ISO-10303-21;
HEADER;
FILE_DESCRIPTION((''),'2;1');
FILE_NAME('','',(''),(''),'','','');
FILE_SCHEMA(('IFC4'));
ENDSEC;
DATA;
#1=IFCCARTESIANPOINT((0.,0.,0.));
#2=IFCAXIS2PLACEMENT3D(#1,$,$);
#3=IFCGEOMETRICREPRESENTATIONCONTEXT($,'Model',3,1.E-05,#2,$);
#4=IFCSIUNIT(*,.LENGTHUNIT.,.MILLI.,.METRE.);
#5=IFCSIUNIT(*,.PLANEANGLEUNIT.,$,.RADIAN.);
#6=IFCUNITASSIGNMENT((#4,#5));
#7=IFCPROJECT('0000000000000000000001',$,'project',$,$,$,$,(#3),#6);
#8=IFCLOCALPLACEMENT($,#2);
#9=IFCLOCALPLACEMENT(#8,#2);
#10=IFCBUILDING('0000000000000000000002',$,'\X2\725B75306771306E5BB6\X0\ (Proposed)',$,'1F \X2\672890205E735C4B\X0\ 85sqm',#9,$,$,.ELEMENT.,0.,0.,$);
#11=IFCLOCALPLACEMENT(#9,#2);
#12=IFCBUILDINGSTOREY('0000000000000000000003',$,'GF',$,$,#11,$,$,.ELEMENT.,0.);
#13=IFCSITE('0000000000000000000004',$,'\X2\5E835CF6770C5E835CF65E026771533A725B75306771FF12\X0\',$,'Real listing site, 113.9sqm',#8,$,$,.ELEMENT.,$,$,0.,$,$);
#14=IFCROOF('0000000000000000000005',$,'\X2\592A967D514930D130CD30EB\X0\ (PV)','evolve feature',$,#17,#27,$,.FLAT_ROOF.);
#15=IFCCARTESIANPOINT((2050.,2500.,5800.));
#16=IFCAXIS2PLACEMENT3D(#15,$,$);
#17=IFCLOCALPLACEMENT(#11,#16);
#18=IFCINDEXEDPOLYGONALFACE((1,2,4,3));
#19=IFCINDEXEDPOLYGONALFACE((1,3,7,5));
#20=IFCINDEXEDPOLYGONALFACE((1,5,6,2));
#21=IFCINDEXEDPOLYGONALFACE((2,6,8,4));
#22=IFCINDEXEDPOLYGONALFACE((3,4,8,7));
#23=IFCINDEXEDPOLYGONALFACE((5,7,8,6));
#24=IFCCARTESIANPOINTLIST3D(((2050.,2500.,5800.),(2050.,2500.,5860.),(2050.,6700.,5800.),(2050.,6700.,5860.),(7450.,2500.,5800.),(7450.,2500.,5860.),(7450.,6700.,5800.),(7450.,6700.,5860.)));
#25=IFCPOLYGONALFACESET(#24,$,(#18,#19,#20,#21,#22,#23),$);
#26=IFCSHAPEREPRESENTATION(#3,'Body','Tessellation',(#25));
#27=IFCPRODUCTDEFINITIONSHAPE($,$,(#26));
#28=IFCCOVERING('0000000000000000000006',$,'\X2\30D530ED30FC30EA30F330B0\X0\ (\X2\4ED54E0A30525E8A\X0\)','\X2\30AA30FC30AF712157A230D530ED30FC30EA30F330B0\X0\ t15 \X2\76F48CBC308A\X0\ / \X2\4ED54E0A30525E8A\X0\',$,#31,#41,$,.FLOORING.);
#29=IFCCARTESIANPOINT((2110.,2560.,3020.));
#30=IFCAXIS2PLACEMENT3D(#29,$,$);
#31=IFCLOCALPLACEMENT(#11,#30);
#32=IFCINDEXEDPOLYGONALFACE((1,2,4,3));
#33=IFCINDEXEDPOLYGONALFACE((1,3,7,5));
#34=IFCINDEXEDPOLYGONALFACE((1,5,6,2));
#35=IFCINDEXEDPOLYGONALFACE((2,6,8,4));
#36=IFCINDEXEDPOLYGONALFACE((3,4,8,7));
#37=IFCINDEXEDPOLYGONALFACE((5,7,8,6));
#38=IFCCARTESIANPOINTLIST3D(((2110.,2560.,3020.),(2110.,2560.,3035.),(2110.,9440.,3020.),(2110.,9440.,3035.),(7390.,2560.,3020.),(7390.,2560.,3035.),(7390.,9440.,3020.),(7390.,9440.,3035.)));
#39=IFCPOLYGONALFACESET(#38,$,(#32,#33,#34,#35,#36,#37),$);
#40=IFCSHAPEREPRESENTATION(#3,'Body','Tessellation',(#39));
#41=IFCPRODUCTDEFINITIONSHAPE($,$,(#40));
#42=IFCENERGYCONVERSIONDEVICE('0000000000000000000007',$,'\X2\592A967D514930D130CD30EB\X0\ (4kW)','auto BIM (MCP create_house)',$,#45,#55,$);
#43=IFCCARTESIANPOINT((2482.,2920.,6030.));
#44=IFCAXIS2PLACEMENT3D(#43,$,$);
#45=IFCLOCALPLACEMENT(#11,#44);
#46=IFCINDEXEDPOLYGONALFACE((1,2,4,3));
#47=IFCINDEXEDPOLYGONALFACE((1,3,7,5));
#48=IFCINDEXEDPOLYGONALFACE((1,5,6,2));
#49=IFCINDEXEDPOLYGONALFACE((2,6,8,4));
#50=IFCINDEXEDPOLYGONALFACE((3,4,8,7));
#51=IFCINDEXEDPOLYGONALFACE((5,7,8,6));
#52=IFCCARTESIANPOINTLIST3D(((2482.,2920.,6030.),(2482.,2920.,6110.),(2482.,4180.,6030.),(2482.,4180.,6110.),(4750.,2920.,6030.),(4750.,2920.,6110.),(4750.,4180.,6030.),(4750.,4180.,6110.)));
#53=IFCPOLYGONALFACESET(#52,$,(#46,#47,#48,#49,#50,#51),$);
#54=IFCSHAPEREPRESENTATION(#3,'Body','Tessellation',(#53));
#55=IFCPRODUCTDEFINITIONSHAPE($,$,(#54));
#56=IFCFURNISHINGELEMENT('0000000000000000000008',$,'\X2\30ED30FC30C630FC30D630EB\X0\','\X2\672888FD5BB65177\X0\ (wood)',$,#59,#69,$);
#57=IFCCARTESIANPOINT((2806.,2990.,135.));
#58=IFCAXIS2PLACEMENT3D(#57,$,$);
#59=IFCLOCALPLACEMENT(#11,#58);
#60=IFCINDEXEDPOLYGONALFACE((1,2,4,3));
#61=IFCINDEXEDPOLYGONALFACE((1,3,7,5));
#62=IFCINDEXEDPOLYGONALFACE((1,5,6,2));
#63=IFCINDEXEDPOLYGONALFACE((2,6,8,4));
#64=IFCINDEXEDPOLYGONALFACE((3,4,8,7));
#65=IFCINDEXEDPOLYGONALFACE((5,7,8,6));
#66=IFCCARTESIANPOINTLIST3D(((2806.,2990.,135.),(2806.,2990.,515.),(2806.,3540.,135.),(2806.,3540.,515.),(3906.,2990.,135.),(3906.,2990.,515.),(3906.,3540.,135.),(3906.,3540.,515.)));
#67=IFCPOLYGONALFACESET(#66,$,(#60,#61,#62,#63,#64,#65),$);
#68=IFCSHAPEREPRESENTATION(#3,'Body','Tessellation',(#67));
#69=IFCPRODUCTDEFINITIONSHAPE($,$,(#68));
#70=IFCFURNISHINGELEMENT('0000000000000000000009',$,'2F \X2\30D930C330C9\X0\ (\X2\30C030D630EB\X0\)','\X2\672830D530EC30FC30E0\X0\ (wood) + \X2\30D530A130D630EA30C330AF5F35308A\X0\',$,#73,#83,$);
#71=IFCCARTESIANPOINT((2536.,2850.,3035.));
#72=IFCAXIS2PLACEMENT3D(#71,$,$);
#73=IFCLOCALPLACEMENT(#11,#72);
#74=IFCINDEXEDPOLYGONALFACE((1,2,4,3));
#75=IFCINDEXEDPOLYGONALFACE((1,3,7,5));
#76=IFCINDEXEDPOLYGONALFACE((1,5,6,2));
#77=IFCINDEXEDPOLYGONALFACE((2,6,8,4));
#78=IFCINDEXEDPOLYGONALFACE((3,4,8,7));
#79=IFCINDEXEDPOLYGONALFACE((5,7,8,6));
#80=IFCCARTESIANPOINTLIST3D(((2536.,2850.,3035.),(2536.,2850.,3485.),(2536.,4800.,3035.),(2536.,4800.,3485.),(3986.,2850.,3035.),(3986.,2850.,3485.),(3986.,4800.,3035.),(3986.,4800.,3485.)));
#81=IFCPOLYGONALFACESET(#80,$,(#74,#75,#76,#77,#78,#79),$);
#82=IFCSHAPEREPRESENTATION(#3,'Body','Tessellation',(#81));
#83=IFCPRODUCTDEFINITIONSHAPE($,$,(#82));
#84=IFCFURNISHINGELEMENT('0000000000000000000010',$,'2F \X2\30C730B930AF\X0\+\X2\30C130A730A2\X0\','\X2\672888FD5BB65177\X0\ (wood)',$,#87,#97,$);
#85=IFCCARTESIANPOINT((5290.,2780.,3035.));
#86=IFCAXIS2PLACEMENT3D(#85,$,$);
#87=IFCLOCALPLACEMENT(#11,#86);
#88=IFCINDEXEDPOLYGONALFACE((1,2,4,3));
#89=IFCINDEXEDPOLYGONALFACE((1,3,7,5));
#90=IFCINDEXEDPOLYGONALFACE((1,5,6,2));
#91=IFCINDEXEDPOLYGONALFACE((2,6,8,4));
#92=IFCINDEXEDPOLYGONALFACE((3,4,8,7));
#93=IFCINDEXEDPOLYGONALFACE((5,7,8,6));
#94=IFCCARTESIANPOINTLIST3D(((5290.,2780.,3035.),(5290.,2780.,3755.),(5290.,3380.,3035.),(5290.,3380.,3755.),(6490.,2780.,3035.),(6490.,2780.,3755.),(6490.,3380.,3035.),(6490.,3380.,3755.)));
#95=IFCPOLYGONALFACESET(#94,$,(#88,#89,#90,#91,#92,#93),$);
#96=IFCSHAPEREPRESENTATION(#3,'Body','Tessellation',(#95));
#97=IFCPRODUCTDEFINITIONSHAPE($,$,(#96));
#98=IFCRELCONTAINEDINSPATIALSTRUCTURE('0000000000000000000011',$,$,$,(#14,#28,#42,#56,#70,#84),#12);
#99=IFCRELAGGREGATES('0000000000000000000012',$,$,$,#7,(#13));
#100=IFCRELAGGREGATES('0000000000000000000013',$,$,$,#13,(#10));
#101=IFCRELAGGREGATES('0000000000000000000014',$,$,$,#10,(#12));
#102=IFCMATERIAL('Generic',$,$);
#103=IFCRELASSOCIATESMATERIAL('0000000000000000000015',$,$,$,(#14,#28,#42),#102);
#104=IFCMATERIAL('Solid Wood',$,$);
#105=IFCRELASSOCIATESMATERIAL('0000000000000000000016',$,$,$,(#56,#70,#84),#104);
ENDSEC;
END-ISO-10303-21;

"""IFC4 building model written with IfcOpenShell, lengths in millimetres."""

from ifc_helpers import new_model, si_unit, frame, frame_2d, origin, place, context, project, spatial, rectangle, extrude, material, element, save


model = new_model("IFC4")

# Units and contexts
model_context = context("Model", 3, precision=1e-05, world=origin())
ifc_project = project(units=[si_unit("LENGTHUNIT", "METRE", prefix="MILLI"), si_unit("PLANEANGLEUNIT", "RADIAN")], contexts=[model_context])

# Site, building, storey
site_placement = place(None, origin())
site = spatial("IfcSite", under=ifc_project, at=site_placement, Name="広島県広島市東区牛田東２", ObjectType="Real listing site, 113.9sqm", CompositionType="ELEMENT", RefElevation=0.0)
building_placement = place(site_placement, origin())
building = spatial("IfcBuilding", under=site, at=building_placement, Name="牛田東の家 (Proposed)", ObjectType="1F 木造平屋 85sqm", CompositionType="ELEMENT", ElevationOfRefHeight=0.0, ElevationOfTerrain=0.0)
storey_placement = place(building_placement, origin())
storey = spatial("IfcBuildingStorey", under=building, at=storey_placement, Name="GF", CompositionType="ELEMENT", Elevation=0.0)

# Shared definitions
ifc_material_1 = material(Name="Solid Wood")

# Shared definitions
ifc_material_2 = material(Name="Generic")

# Roof
roof_1_placement = place(storey_placement, frame((2050.0, 2500.0, 5800.0)))
element("IfcRoof", 1, at=roof_1_placement, inside=storey, material=ifc_material_2, Name="太陽光パネル (PV)", Description="evolve feature", PredefinedType="FLAT_ROOF", context=model_context, shape_type="SweptSolid", body=[
    extrude(rectangle(XDim=5400.0, YDim=4200.0, at=frame_2d((2700.0, 2100.0))), frame((2050.0, 2500.0, 5800.0)), (0.0, 0.0, 1.0), 60.0),
])

# Covering
covering_placement = place(storey_placement, frame((2110.0, 2560.0, 3020.0)))
element("IfcCovering", 2, at=covering_placement, inside=storey, material=ifc_material_2, Name="フローリング (仕上げ床)", Description="オーク無垢フローリング t15 直貼り / 仕上げ床", PredefinedType="FLOORING", context=model_context, shape_type="SweptSolid", body=[
    extrude(rectangle(XDim=5280.0, YDim=6880.0, at=frame_2d((2640.0, 3440.0))), frame((2110.0, 2560.0, 3020.0)), (0.0, 0.0, 1.0), 15.0),
])

# Energy conversion device
energy_conversion_device_placement = place(storey_placement, frame((2482.0, 2920.0, 6030.0)))
element("IfcEnergyConversionDevice", 3, at=energy_conversion_device_placement, inside=storey, material=ifc_material_2, Name="太陽光パネル (4kW)", Description="auto BIM (MCP create_house)", context=model_context, shape_type="SweptSolid", body=[
    extrude(rectangle(XDim=2268.0, YDim=1260.0, at=frame_2d((1134.0, 630.0))), frame((2482.0, 2920.0, 6030.0)), (0.0, 0.0, 1.0), 80.0),
])

# Furnishing elements
furnishing_1_placement = place(storey_placement, frame((2806.0, 2990.0, 135.0)))
element("IfcFurnishingElement", 4, at=furnishing_1_placement, inside=storey, material=ifc_material_1, Name="ローテーブル", Description="木製家具 (wood)", context=model_context, shape_type="SweptSolid", body=[
    extrude(rectangle(XDim=1100.0, YDim=550.0, at=frame_2d((550.0, 275.0))), frame((2806.0, 2990.0, 135.0)), (0.0, 0.0, 1.0), 380.0),
])
furnishing_2_placement = place(storey_placement, frame((2536.0, 2850.0, 3035.0)))
element("IfcFurnishingElement", 5, at=furnishing_2_placement, inside=storey, material=ifc_material_1, Name="2F ベッド (ダブル)", Description="木フレーム (wood) + ファブリック張り", context=model_context, shape_type="SweptSolid", body=[
    extrude(rectangle(XDim=1450.0, YDim=1950.0, at=frame_2d((725.0, 975.0))), frame((2536.0, 2850.0, 3035.0)), (0.0, 0.0, 1.0), 450.0),
])
furnishing_3_placement = place(storey_placement, frame((5290.0, 2780.0, 3035.0)))
element("IfcFurnishingElement", 6, at=furnishing_3_placement, inside=storey, material=ifc_material_1, Name="2F デスク+チェア", Description="木製家具 (wood)", context=model_context, shape_type="SweptSolid", body=[
    extrude(rectangle(XDim=1200.0, YDim=600.0, at=frame_2d((600.0, 300.0))), frame((5290.0, 2780.0, 3035.0)), (0.0, 0.0, 1.0), 720.0),
])

save(model, "model.ifc")
